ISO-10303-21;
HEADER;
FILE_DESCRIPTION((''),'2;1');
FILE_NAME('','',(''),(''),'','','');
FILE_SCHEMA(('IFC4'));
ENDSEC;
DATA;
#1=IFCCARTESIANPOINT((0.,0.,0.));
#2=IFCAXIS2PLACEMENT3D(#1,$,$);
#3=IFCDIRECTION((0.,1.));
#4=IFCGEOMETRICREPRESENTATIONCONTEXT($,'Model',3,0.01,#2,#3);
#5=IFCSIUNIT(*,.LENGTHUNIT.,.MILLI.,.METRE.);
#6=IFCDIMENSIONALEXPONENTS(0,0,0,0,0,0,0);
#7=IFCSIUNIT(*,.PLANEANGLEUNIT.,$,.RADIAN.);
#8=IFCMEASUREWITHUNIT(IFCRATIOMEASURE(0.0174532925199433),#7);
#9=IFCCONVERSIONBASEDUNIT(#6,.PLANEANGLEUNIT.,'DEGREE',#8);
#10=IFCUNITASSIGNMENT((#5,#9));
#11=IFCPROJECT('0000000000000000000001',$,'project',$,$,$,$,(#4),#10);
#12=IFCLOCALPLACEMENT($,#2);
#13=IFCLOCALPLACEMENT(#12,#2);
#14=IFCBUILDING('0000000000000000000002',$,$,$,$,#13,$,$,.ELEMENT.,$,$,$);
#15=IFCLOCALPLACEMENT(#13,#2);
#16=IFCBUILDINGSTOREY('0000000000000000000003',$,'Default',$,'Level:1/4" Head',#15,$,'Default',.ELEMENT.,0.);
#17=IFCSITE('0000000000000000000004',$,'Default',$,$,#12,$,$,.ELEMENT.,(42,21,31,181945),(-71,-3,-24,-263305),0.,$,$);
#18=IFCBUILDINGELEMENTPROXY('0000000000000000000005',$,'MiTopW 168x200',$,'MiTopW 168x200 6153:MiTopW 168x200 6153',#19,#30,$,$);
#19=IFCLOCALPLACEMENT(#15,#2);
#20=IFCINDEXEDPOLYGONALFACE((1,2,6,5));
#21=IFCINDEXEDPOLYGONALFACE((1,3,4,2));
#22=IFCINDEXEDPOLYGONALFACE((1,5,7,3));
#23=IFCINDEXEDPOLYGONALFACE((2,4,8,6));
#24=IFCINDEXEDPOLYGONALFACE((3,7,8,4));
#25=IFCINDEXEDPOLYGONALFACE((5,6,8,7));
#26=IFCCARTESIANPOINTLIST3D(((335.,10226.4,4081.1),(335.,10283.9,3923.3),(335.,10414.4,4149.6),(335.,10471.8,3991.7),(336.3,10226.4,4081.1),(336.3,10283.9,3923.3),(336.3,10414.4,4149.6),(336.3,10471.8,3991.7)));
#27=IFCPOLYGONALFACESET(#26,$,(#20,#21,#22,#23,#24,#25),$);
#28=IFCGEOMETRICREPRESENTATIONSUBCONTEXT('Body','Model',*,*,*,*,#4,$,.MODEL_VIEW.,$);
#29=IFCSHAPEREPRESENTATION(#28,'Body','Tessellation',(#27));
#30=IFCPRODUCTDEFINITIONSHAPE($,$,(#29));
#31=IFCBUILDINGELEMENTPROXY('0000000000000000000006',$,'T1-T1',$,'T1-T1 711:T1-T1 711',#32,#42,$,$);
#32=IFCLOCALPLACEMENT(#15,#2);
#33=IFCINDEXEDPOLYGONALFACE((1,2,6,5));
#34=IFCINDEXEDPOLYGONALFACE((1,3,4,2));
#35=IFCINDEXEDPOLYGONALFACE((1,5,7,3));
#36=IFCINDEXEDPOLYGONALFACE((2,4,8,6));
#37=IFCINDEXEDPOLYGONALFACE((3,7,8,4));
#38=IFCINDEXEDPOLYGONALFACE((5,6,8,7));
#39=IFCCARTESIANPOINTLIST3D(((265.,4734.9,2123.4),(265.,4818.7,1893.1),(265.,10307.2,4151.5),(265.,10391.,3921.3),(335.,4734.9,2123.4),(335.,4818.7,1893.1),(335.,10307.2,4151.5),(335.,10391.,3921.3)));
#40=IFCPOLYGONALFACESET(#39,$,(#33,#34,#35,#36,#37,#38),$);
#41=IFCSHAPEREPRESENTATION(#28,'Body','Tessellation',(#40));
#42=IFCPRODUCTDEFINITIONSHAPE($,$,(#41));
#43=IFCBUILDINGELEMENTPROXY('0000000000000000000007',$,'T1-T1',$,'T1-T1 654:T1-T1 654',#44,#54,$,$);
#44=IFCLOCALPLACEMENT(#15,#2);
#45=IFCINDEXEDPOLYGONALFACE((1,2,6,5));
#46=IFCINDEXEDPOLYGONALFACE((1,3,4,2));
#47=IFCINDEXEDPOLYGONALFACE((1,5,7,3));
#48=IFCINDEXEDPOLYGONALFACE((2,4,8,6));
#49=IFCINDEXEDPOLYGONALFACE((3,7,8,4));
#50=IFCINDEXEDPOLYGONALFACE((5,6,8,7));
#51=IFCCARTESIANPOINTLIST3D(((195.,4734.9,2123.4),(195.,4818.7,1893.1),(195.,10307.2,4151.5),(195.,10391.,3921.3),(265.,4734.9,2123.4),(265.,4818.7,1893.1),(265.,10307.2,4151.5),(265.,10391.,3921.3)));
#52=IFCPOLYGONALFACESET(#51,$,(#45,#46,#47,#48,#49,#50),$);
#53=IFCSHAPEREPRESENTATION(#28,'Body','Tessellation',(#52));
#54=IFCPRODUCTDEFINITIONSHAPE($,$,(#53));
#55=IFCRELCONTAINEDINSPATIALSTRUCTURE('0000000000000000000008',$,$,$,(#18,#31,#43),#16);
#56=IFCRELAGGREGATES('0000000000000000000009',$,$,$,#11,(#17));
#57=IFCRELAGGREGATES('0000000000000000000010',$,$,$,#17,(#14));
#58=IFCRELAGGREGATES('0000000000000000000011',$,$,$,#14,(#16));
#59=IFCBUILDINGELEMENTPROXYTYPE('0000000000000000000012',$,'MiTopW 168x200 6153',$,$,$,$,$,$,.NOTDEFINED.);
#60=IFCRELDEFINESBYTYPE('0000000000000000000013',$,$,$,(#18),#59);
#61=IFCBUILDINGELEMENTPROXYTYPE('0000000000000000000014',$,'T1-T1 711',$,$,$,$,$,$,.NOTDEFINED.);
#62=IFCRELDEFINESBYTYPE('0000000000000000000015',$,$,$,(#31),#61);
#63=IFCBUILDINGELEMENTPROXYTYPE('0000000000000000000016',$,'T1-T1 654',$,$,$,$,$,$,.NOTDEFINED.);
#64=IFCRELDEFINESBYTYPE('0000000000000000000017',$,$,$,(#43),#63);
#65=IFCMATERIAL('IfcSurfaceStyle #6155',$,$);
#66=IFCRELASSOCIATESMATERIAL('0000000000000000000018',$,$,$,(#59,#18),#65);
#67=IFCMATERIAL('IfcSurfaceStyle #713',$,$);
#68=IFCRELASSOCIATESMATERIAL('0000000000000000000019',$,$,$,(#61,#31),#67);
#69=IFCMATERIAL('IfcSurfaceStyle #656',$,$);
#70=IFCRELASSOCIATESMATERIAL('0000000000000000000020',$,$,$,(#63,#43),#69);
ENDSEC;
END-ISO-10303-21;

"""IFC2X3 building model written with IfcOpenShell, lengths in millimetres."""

from ifc_helpers import new_model, entity, si_unit, converted_unit, direction, frame, origin, place, context, subcontext, project, spatial, polyline, outline, extrude, source, transform, mapped, material, type_object, type_shapes, element, save


model = new_model("IFC2X3")

# Units and contexts
model_context = context("Model", 3, precision=0.01, world=origin(), true_north=direction((0.0, 1.0)))
body_context = subcontext(model_context, "Body", "Model", "MODEL_VIEW")
ifc_project = project(units=[si_unit("LENGTHUNIT", "METRE", prefix="MILLI"), converted_unit("PLANEANGLEUNIT", "DEGREE", entity("IfcRatioMeasure", 0.0174532925199433), si_unit("PLANEANGLEUNIT", "RADIAN"), dimensions=[0, 0, 0, 0, 0, 0, 0])], contexts=[model_context])

# Site, building, storey
site_placement = place(None, origin())
site = spatial("IfcSite", under=ifc_project, at=site_placement, Name="Default", CompositionType="ELEMENT", RefLatitude=(42, 21, 31, 181945), RefLongitude=(-71, -3, -24, -263305), RefElevation=0.0)
building_placement = place(site_placement, origin())
building = spatial("IfcBuilding", under=site, at=building_placement, CompositionType="ELEMENT")
storey_placement = place(building_placement, origin())
storey = spatial("IfcBuildingStorey", under=building, at=storey_placement, Name="Default", ObjectType="Level:1/4\" Head", LongName="Default", CompositionType="ELEMENT", Elevation=0.0)

# Building element proxies
ifc_material_1 = material(Name="IfcSurfaceStyle #6155")
building_element_proxy_type_1 = type_object("IfcBuildingElementProxyType", Name="MiTopW 168x200 6153", PredefinedType="NOTDEFINED", material=ifc_material_1)
shared_shape_1 = source(origin(), body_context, "Body", "SweptSolid", [
    extrude(outline(polyline([(-100.0, -84.0), (100.0, -84.0), (100.0, 84.0), (-100.0, 84.0), (-100.0, -84.0)])), frame((100.0, 84.0, 0.0), z_axis=(0.0, 0.0, 1.0), x_axis=(-1.0, 0.0, 0.0)), (0.0, 0.0, 1.0), 1.3),
])
type_shapes(building_element_proxy_type_1, [shared_shape_1])
proxy_1_placement = place(building_placement, frame((336.3, 10226.4, 4081.1), z_axis=(-1.0, 0.0, 0.0), x_axis=(0.0, 0.939693, 0.34202)))
element("IfcBuildingElementProxy", 1, at=proxy_1_placement, inside=storey, type_object=building_element_proxy_type_1, material=ifc_material_1, Name="MiTopW 168x200", ObjectType="MiTopW 168x200 6153:MiTopW 168x200 6153", context=body_context, shape_type="MappedRepresentation", body=[
    mapped(shared_shape_1, transform((0.0, 0.0, 0.0), scale=1.0)),
])
ifc_material_2 = material(Name="IfcSurfaceStyle #713")
building_element_proxy_type_2 = type_object("IfcBuildingElementProxyType", Name="T1-T1 711", PredefinedType="NOTDEFINED", material=ifc_material_2)
shared_shape_2 = source(origin(), body_context, "Body", "SweptSolid", [
    extrude(outline(polyline([(-2965.0, -122.5), (2965.0, -122.5), (2965.0, 122.5), (-2965.0, 122.5), (-2965.0, -122.5)])), frame((2965.0, 122.5, 0.0), z_axis=(0.0, 0.0, 1.0), x_axis=(-1.0, 0.0, 0.0)), (0.0, 0.0, 1.0), 70.0),
])
type_shapes(building_element_proxy_type_2, [shared_shape_2])
proxy_2_placement = place(building_placement, frame((335.0, 10391.0, 3921.3), z_axis=(-1.0, 0.0, 0.0), x_axis=(0.0, -0.939693, -0.34202)))
element("IfcBuildingElementProxy", 2, at=proxy_2_placement, inside=storey, type_object=building_element_proxy_type_2, material=ifc_material_2, Name="T1-T1", ObjectType="T1-T1 711:T1-T1 711", context=body_context, shape_type="MappedRepresentation", body=[
    mapped(shared_shape_2, transform((0.0, 0.0, 0.0), scale=1.0)),
])
ifc_material_3 = material(Name="IfcSurfaceStyle #656")
building_element_proxy_type_3 = type_object("IfcBuildingElementProxyType", Name="T1-T1 654", PredefinedType="NOTDEFINED", material=ifc_material_3)
shared_shape_3 = source(origin(), body_context, "Body", "SweptSolid", [
    extrude(outline(polyline([(-2965.0, -122.5), (2965.0, -122.5), (2965.0, 122.5), (-2965.0, 122.5), (-2965.0, -122.5)])), frame((2965.0, 122.5, 0.0), z_axis=(0.0, 0.0, 1.0), x_axis=(-1.0, 0.0, 0.0)), (0.0, 0.0, 1.0), 70.0),
])
type_shapes(building_element_proxy_type_3, [shared_shape_3])
proxy_3_placement = place(building_placement, frame((265.0, 10391.0, 3921.3), z_axis=(-1.0, 0.0, 0.0), x_axis=(0.0, -0.939693, -0.34202)))
element("IfcBuildingElementProxy", 3, at=proxy_3_placement, inside=storey, type_object=building_element_proxy_type_3, material=ifc_material_3, Name="T1-T1", ObjectType="T1-T1 654:T1-T1 654", context=body_context, shape_type="MappedRepresentation", body=[
    mapped(shared_shape_3, transform((0.0, 0.0, 0.0), scale=1.0)),
])

save(model, "model.ifc")
